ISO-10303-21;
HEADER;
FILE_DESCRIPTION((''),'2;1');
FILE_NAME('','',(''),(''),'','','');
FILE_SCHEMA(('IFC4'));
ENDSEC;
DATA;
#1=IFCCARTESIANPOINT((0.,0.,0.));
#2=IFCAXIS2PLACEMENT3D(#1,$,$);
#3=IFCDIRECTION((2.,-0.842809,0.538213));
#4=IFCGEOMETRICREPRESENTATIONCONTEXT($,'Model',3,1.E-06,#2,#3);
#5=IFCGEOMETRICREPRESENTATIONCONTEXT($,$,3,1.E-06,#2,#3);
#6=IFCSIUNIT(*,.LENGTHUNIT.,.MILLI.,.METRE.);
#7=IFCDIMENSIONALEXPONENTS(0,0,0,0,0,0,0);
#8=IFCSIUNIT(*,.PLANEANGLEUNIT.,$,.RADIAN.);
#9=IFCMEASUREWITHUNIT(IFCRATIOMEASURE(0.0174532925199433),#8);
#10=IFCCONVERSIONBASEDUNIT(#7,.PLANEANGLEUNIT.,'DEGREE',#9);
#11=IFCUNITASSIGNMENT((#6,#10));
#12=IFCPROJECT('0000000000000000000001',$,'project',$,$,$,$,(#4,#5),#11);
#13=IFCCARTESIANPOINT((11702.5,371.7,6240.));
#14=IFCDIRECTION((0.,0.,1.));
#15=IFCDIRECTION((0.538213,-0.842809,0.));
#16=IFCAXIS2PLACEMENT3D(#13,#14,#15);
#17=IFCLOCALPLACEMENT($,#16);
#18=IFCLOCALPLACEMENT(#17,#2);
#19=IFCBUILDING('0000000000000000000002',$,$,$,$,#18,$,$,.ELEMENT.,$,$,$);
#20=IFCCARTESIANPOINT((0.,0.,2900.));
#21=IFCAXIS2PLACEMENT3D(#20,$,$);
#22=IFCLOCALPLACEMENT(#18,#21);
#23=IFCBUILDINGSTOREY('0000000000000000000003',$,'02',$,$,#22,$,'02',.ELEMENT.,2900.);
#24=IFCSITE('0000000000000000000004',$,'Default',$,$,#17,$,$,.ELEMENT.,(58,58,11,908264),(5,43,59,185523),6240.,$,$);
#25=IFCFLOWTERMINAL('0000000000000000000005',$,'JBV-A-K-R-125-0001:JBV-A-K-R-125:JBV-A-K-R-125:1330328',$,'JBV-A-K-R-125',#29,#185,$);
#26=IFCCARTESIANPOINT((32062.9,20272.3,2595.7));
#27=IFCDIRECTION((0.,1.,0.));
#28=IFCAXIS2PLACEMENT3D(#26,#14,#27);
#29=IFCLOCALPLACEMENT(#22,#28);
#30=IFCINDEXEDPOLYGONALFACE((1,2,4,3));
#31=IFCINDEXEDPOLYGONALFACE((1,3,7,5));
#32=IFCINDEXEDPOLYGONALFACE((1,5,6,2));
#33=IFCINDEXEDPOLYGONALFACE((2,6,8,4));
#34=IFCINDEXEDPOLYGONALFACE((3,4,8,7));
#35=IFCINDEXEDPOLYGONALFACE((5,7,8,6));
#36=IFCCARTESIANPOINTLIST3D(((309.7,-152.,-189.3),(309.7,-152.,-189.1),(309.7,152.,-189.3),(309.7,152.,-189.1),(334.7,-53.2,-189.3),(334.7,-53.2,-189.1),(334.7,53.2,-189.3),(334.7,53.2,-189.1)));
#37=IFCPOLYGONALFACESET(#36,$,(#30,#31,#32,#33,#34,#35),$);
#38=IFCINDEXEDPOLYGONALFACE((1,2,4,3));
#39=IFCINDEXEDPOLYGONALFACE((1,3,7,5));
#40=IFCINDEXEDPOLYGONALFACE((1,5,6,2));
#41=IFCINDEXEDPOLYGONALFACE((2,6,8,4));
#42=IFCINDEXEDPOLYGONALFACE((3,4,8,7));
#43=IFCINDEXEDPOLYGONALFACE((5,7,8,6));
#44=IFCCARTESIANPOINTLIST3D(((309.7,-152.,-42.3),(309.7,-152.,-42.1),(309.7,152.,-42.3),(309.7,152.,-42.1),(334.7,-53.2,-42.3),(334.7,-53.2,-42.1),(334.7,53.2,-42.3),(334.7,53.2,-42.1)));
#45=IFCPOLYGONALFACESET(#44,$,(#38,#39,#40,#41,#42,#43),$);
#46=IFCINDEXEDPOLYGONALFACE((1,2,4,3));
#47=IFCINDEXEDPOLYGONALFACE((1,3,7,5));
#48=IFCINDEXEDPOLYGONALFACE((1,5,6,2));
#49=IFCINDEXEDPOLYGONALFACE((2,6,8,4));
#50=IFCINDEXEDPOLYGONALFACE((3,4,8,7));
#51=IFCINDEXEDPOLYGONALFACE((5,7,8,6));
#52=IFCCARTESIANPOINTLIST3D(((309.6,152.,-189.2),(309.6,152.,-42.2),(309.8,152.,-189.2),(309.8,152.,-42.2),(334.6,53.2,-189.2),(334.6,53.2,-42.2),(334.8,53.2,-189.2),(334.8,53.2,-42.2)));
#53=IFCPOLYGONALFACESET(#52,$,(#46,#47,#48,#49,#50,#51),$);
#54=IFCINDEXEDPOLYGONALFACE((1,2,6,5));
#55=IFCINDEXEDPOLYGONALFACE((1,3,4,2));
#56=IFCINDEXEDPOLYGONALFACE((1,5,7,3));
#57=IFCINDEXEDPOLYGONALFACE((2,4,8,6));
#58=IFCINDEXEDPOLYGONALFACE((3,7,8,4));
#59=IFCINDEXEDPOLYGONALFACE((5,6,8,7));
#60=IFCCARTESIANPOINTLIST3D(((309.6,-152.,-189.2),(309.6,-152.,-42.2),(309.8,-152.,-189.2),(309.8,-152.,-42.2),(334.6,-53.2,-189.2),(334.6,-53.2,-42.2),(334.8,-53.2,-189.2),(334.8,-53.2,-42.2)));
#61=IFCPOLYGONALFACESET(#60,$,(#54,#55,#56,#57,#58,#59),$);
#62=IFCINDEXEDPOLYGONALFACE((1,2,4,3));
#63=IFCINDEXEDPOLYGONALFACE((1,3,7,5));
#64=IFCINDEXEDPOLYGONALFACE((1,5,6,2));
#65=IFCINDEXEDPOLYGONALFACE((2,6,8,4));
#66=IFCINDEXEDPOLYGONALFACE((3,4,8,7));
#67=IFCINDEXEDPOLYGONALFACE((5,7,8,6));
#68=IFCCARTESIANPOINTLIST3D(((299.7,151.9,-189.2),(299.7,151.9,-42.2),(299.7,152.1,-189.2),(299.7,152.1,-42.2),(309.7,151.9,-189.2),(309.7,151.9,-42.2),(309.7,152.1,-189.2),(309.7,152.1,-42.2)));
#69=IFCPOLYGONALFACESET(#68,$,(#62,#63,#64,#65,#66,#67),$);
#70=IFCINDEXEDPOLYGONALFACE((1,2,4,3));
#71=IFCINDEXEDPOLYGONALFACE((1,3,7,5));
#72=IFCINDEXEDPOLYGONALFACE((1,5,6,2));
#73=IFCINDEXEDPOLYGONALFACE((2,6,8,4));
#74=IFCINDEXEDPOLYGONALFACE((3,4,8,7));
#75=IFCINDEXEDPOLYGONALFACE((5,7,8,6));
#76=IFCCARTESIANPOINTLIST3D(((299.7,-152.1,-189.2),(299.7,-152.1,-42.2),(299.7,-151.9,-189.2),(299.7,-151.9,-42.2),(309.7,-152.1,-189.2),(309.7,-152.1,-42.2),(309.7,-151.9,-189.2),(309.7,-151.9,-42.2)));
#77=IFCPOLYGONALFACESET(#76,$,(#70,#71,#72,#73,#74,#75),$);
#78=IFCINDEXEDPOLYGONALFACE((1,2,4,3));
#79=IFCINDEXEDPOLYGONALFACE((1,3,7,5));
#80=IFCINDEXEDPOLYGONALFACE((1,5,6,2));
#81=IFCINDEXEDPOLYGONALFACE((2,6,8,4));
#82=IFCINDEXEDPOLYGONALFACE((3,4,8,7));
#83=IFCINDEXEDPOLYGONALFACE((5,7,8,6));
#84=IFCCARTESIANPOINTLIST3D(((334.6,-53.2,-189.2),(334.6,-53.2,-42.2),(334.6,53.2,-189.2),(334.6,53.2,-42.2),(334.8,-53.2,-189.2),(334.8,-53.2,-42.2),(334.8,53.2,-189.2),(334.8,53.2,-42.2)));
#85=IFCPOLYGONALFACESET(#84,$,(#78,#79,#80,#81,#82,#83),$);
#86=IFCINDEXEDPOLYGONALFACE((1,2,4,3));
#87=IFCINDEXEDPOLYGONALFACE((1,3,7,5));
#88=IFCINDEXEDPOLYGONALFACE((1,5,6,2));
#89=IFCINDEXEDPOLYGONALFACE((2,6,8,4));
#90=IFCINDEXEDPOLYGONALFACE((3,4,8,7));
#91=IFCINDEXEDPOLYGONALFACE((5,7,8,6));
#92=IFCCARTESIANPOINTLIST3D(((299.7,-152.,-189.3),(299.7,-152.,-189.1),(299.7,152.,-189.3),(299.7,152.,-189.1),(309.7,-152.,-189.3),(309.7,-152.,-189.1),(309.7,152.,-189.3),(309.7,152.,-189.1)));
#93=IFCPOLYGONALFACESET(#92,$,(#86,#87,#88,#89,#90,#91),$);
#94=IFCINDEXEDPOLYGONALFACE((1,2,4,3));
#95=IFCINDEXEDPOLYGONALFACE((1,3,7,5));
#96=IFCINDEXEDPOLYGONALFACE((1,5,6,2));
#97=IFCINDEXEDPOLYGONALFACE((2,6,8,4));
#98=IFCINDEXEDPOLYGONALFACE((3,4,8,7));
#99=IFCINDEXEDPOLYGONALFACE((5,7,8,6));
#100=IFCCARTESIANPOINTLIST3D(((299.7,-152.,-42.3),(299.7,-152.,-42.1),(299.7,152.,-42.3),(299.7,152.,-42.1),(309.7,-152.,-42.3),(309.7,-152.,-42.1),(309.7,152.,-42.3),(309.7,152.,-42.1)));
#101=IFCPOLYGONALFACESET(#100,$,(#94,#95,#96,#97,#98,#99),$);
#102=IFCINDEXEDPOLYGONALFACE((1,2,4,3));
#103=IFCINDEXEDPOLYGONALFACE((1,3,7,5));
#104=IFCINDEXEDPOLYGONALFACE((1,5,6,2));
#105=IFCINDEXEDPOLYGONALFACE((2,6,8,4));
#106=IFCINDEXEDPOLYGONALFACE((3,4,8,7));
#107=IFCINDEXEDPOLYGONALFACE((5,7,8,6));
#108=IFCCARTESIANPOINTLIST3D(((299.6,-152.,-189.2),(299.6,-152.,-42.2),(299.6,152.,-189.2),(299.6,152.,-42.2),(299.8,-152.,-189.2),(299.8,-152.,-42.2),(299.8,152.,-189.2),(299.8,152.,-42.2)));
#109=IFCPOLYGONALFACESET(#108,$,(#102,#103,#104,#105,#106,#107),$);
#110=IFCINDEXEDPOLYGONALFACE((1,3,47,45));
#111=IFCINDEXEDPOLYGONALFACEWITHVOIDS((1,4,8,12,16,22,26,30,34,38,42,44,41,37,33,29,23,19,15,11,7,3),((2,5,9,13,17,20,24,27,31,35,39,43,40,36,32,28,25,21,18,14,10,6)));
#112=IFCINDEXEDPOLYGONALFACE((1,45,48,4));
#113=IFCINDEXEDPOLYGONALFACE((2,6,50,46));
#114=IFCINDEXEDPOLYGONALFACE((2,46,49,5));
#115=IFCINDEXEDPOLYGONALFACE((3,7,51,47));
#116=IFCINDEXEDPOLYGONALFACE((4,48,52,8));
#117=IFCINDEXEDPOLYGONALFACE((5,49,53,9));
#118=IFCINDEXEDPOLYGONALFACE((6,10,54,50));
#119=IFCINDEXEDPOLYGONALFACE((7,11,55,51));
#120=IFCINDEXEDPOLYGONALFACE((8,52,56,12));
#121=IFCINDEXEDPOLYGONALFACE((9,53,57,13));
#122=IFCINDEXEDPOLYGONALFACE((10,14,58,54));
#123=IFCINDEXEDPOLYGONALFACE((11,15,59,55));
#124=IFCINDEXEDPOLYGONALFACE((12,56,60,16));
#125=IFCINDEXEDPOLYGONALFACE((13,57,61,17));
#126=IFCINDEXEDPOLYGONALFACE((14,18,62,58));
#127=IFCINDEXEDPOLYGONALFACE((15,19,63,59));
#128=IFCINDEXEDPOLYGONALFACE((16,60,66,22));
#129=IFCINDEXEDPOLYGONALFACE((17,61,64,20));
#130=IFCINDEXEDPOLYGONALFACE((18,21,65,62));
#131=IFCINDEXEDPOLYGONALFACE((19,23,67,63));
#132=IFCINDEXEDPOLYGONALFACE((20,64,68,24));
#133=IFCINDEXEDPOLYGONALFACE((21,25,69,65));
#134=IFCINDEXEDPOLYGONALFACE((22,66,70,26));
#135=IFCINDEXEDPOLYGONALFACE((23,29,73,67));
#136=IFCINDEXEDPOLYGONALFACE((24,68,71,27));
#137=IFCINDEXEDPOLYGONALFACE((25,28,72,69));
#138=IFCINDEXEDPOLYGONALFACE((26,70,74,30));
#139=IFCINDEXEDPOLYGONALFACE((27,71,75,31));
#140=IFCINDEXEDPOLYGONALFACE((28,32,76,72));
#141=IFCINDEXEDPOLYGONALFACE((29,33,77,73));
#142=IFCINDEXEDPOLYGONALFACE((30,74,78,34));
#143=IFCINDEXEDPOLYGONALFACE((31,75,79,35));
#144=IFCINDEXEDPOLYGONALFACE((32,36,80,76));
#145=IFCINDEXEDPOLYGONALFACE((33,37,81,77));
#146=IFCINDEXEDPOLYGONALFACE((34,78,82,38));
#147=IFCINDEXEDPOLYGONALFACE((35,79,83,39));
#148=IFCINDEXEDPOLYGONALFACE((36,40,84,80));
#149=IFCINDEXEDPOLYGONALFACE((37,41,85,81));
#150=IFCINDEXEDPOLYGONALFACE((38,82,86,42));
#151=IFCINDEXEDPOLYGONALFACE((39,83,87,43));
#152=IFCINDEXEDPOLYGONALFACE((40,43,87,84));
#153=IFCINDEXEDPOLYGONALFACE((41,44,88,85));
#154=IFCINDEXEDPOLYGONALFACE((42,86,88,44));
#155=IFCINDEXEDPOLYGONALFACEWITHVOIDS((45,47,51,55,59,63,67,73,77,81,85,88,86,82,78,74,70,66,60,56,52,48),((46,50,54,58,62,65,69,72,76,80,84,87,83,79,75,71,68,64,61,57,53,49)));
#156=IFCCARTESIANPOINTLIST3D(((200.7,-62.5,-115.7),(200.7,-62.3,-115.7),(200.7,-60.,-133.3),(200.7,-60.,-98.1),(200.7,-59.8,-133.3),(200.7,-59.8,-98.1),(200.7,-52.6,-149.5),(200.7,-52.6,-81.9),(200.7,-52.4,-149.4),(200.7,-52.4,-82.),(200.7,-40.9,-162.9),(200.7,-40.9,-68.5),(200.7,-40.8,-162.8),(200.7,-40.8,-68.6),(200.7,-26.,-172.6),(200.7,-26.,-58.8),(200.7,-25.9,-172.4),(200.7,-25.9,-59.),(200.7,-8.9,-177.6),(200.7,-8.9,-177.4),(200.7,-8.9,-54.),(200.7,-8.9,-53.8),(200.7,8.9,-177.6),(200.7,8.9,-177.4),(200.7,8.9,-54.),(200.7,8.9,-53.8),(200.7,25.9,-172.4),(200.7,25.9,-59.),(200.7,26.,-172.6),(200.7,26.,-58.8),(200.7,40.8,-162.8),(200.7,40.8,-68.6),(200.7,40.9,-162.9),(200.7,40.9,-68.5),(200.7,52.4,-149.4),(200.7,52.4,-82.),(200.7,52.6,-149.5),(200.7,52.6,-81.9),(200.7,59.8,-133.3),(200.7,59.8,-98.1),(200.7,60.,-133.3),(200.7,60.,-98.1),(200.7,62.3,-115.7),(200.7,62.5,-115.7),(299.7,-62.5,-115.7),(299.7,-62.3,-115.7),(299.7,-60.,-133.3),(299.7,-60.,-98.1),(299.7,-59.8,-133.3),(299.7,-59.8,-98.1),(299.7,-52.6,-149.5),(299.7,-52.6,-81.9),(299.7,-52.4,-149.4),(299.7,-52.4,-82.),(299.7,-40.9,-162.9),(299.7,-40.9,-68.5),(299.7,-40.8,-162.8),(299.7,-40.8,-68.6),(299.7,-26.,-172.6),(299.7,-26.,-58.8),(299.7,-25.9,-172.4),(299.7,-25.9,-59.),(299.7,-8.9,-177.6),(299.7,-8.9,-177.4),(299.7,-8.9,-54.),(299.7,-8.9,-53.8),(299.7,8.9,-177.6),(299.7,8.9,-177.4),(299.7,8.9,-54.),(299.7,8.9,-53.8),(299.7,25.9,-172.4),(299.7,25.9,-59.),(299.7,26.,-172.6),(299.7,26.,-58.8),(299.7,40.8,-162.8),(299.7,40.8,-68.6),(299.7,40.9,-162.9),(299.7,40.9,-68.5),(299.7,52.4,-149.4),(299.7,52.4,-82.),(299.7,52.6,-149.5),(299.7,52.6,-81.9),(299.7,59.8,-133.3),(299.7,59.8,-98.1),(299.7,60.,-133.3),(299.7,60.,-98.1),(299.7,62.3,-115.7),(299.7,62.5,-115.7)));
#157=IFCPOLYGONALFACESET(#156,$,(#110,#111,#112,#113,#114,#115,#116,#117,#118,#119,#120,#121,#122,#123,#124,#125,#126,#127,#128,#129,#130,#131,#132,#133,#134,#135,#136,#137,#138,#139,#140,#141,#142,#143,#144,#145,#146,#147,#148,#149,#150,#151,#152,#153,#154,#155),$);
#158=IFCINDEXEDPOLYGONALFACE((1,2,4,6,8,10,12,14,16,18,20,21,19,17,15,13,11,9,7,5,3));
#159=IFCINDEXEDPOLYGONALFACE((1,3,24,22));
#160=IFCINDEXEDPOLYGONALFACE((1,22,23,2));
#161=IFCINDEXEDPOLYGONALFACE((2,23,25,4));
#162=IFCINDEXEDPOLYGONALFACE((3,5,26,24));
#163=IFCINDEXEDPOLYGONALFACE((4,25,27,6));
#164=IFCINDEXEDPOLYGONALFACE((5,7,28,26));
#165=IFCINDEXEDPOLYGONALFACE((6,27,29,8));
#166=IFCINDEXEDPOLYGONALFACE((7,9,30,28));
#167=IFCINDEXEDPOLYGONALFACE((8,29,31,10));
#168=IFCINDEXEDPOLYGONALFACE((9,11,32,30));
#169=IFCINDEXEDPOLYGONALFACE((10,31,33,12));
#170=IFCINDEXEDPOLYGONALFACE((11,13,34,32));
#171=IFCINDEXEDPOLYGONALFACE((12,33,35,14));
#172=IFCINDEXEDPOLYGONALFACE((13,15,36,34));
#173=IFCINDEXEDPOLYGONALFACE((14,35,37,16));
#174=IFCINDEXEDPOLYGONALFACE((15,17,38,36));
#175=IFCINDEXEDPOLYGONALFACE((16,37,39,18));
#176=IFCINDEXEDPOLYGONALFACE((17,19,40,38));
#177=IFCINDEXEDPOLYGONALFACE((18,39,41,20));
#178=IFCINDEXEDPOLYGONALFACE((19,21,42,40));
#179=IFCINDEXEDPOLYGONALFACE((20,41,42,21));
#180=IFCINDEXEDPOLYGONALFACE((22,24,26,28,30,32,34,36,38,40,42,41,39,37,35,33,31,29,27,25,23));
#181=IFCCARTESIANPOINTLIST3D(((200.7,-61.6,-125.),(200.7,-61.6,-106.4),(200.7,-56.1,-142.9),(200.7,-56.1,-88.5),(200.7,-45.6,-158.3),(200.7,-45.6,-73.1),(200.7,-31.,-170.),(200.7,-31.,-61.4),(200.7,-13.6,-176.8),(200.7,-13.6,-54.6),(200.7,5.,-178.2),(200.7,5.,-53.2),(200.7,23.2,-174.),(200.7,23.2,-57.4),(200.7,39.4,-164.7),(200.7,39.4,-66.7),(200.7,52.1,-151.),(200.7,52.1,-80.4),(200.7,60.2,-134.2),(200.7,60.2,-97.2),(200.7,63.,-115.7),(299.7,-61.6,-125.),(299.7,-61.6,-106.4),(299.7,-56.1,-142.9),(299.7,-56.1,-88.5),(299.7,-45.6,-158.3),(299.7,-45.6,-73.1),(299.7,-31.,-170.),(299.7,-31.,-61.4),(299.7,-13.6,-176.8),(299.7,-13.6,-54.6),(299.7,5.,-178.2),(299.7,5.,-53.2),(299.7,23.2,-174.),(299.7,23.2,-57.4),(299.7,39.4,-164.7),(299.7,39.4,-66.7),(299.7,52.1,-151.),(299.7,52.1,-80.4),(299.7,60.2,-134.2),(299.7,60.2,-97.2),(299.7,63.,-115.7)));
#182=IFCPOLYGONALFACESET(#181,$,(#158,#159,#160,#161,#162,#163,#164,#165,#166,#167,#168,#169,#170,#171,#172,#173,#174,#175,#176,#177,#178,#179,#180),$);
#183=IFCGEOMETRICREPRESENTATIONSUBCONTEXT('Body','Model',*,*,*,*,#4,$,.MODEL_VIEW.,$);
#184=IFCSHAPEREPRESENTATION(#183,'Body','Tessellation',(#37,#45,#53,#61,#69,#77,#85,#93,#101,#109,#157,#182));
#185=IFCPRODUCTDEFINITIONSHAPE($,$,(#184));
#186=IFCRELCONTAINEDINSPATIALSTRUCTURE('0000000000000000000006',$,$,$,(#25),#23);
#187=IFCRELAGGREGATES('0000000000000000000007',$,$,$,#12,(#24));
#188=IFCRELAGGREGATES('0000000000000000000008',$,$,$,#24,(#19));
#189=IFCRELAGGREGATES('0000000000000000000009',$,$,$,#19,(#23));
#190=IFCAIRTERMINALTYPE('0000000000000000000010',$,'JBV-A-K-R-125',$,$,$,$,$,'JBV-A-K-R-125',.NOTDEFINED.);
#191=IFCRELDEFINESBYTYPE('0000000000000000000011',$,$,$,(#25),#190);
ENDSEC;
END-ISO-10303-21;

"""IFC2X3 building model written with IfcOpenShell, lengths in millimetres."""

from ifc_helpers import new_model, entity, si_unit, converted_unit, direction, frame, frame_2d, origin, origin_2d_with_axis, place, context, subcontext, project, spatial, polyline, circle_curve, parameter, trimmed, segment, composite_curve, rectangle, circle, outline, extrude, source, transform, mapped, type_object, type_shapes, element, save


model = new_model("IFC2X3")

# Units and contexts
model_context = context("Model", 3, precision=1e-06, world=origin(), true_north=direction((2.0, -0.842809, 0.538213)))
context_of_model = context(None, 3, precision=1e-06, world=origin(), true_north=direction((2.0, -0.842809, 0.538213)))
body_context = subcontext(model_context, "Body", "Model", "MODEL_VIEW")
ifc_project = project(units=[si_unit("LENGTHUNIT", "METRE", prefix="MILLI"), converted_unit("PLANEANGLEUNIT", "DEGREE", entity("IfcRatioMeasure", 0.0174532925199433), si_unit("PLANEANGLEUNIT", "RADIAN"), dimensions=[0, 0, 0, 0, 0, 0, 0])], contexts=[model_context, context_of_model])

# Site, building, storey
site_placement = place(None, frame((11702.5, 371.7, 6240.0), z_axis=(0.0, 0.0, 1.0), x_axis=(0.538213, -0.842809, 0.0)))
site = spatial("IfcSite", under=ifc_project, at=site_placement, Name="Default", CompositionType="ELEMENT", RefLatitude=(58, 58, 11, 908264), RefLongitude=(5, 43, 59, 185523), RefElevation=6240.0)
building_placement = place(site_placement, origin())
building = spatial("IfcBuilding", under=site, at=building_placement, CompositionType="ELEMENT")
storey_placement = place(building_placement, frame((0.0, 0.0, 2900.0)))
storey = spatial("IfcBuildingStorey", under=building, at=storey_placement, Name="02", LongName="02", CompositionType="ELEMENT", Elevation=2900.0)

# Flow terminal
air_terminal_type_1 = type_object("IfcAirTerminalType", Name="JBV-A-K-R-125", ElementType="JBV-A-K-R-125", PredefinedType="NOTDEFINED")
shared_shape_1 = source(origin(), body_context, "Body", "SweptSolid", [
    extrude(outline(polyline([(-152.0, -12.5), (152.0, -12.5), (53.2, 12.5), (-53.2, 12.5), (-152.0, -12.5)])), frame((322.2, 0.0, -189.3), z_axis=(0.0, 0.0, 1.0), x_axis=(0.0, -1.0, 0.0)), (0.0, 0.0, 1.0), 0.2),
    extrude(outline(polyline([(-152.0, -12.5), (152.0, -12.5), (53.2, 12.5), (-53.2, 12.5), (-152.0, -12.5)])), frame((322.2, 0.0, -42.3), z_axis=(0.0, 0.0, 1.0), x_axis=(0.0, -1.0, 0.0)), (0.0, 0.0, 1.0), 0.2),
    extrude(rectangle(XDim=0.2, YDim=101.9, at=frame_2d((0.0, 0.0), x_axis=(1.0, 0.0))), frame((322.2, 102.6, -189.2), z_axis=(0.0, 0.0, 1.0), x_axis=(0.969446, 0.245305, 0.0)), (0.0, 0.0, 1.0), 147.0),
    extrude(rectangle(XDim=0.2, YDim=101.9, at=frame_2d((0.0, 0.0), x_axis=(1.0, 0.0))), frame((322.2, -102.6, -189.2), z_axis=(0.0, 0.0, 1.0), x_axis=(-0.969446, 0.245305, 0.0)), (0.0, 0.0, 1.0), 147.0),
    extrude(rectangle(XDim=0.2, YDim=10.0, at=frame_2d((0.0, 0.0), x_axis=(1.0, 0.0))), frame((304.7, 152.0, -189.2), z_axis=(0.0, 0.0, 1.0), x_axis=(0.0, 1.0, 0.0)), (0.0, 0.0, 1.0), 147.0),
    extrude(rectangle(XDim=0.2, YDim=10.0, at=frame_2d((0.0, 0.0), x_axis=(1.0, 0.0))), frame((304.7, -152.0, -189.2), z_axis=(0.0, 0.0, 1.0), x_axis=(0.0, 1.0, 0.0)), (0.0, 0.0, 1.0), 147.0),
    extrude(rectangle(XDim=0.2, YDim=106.4, at=frame_2d((0.0, 0.0), x_axis=(1.0, 0.0))), frame((334.7, 0.0, -189.2)), (0.0, 0.0, 1.0), 147.0),
    extrude(rectangle(XDim=304.0, YDim=10.0, at=frame_2d((0.0, 0.0), x_axis=(1.0, 0.0))), frame((304.7, 0.0, -189.3), z_axis=(0.0, 0.0, 1.0), x_axis=(0.0, -1.0, 0.0)), (0.0, 0.0, 1.0), 0.2),
    extrude(rectangle(XDim=304.0, YDim=10.0, at=frame_2d((0.0, 0.0), x_axis=(1.0, 0.0))), frame((304.7, 0.0, -42.3), z_axis=(0.0, 0.0, 1.0), x_axis=(0.0, -1.0, 0.0)), (0.0, 0.0, 1.0), 0.2),
    extrude(rectangle(XDim=0.2, YDim=304.0, at=frame_2d((0.0, 0.0), x_axis=(1.0, 0.0))), frame((299.7, 0.0, -189.2)), (0.0, 0.0, 1.0), 147.0),
    extrude(outline(composite_curve([segment(trimmed(circle_curve(origin_2d_with_axis(), 62.5), [parameter(0.0)], [parameter(180.0)], True, "PARAMETER"), True, "CONTINUOUS"), segment(trimmed(circle_curve(origin_2d_with_axis(), 62.5), [parameter(180.0)], [parameter(360.0)], True, "PARAMETER"), True, "CONTINUOUS")], self_intersect=False), holes=[composite_curve([segment(trimmed(circle_curve(origin_2d_with_axis(), 62.3), [parameter(180.0)], [parameter(360.0)], True, "PARAMETER"), False, "CONTINUOUS"), segment(trimmed(circle_curve(origin_2d_with_axis(), 62.3), [parameter(0.0)], [parameter(180.0)], True, "PARAMETER"), False, "CONTINUOUS")], self_intersect=False)]), frame((200.7, 0.0, -115.7), z_axis=(1.0, 0.0, 0.0), x_axis=(0.0, 1.0, 0.0)), (0.0, 0.0, 1.0), 99.0),
    extrude(circle(Radius=62.6, at=frame_2d((0.0, 0.0), x_axis=(1.0, 0.0))), frame((200.7, 0.3, -115.7), z_axis=(1.0, 0.0, 0.0), x_axis=(0.0, 1.0, 0.0)), (0.0, 0.0, 1.0), 99.0),
])
type_shapes(air_terminal_type_1, [shared_shape_1])
for number, where, z_axis, x_axis, name in (
    (1, (32062.9, 20272.3, 2595.7), (0.0, 0.0, 1.0), (0.0, 1.0, 0.0), "JBV-A-K-R-125-0001:JBV-A-K-R-125:JBV-A-K-R-125:1330328"),
):
    element("IfcFlowTerminal", number, at=place(storey_placement, frame(where, z_axis=z_axis, x_axis=x_axis)), inside=storey, type_object=air_terminal_type_1, Name=name, ObjectType="JBV-A-K-R-125", context=body_context, shape_type="MappedRepresentation", body=[
        mapped(shared_shape_1, transform((0.0, 0.0, 0.0), scale=1.0)),
    ])

save(model, "model.ifc")
